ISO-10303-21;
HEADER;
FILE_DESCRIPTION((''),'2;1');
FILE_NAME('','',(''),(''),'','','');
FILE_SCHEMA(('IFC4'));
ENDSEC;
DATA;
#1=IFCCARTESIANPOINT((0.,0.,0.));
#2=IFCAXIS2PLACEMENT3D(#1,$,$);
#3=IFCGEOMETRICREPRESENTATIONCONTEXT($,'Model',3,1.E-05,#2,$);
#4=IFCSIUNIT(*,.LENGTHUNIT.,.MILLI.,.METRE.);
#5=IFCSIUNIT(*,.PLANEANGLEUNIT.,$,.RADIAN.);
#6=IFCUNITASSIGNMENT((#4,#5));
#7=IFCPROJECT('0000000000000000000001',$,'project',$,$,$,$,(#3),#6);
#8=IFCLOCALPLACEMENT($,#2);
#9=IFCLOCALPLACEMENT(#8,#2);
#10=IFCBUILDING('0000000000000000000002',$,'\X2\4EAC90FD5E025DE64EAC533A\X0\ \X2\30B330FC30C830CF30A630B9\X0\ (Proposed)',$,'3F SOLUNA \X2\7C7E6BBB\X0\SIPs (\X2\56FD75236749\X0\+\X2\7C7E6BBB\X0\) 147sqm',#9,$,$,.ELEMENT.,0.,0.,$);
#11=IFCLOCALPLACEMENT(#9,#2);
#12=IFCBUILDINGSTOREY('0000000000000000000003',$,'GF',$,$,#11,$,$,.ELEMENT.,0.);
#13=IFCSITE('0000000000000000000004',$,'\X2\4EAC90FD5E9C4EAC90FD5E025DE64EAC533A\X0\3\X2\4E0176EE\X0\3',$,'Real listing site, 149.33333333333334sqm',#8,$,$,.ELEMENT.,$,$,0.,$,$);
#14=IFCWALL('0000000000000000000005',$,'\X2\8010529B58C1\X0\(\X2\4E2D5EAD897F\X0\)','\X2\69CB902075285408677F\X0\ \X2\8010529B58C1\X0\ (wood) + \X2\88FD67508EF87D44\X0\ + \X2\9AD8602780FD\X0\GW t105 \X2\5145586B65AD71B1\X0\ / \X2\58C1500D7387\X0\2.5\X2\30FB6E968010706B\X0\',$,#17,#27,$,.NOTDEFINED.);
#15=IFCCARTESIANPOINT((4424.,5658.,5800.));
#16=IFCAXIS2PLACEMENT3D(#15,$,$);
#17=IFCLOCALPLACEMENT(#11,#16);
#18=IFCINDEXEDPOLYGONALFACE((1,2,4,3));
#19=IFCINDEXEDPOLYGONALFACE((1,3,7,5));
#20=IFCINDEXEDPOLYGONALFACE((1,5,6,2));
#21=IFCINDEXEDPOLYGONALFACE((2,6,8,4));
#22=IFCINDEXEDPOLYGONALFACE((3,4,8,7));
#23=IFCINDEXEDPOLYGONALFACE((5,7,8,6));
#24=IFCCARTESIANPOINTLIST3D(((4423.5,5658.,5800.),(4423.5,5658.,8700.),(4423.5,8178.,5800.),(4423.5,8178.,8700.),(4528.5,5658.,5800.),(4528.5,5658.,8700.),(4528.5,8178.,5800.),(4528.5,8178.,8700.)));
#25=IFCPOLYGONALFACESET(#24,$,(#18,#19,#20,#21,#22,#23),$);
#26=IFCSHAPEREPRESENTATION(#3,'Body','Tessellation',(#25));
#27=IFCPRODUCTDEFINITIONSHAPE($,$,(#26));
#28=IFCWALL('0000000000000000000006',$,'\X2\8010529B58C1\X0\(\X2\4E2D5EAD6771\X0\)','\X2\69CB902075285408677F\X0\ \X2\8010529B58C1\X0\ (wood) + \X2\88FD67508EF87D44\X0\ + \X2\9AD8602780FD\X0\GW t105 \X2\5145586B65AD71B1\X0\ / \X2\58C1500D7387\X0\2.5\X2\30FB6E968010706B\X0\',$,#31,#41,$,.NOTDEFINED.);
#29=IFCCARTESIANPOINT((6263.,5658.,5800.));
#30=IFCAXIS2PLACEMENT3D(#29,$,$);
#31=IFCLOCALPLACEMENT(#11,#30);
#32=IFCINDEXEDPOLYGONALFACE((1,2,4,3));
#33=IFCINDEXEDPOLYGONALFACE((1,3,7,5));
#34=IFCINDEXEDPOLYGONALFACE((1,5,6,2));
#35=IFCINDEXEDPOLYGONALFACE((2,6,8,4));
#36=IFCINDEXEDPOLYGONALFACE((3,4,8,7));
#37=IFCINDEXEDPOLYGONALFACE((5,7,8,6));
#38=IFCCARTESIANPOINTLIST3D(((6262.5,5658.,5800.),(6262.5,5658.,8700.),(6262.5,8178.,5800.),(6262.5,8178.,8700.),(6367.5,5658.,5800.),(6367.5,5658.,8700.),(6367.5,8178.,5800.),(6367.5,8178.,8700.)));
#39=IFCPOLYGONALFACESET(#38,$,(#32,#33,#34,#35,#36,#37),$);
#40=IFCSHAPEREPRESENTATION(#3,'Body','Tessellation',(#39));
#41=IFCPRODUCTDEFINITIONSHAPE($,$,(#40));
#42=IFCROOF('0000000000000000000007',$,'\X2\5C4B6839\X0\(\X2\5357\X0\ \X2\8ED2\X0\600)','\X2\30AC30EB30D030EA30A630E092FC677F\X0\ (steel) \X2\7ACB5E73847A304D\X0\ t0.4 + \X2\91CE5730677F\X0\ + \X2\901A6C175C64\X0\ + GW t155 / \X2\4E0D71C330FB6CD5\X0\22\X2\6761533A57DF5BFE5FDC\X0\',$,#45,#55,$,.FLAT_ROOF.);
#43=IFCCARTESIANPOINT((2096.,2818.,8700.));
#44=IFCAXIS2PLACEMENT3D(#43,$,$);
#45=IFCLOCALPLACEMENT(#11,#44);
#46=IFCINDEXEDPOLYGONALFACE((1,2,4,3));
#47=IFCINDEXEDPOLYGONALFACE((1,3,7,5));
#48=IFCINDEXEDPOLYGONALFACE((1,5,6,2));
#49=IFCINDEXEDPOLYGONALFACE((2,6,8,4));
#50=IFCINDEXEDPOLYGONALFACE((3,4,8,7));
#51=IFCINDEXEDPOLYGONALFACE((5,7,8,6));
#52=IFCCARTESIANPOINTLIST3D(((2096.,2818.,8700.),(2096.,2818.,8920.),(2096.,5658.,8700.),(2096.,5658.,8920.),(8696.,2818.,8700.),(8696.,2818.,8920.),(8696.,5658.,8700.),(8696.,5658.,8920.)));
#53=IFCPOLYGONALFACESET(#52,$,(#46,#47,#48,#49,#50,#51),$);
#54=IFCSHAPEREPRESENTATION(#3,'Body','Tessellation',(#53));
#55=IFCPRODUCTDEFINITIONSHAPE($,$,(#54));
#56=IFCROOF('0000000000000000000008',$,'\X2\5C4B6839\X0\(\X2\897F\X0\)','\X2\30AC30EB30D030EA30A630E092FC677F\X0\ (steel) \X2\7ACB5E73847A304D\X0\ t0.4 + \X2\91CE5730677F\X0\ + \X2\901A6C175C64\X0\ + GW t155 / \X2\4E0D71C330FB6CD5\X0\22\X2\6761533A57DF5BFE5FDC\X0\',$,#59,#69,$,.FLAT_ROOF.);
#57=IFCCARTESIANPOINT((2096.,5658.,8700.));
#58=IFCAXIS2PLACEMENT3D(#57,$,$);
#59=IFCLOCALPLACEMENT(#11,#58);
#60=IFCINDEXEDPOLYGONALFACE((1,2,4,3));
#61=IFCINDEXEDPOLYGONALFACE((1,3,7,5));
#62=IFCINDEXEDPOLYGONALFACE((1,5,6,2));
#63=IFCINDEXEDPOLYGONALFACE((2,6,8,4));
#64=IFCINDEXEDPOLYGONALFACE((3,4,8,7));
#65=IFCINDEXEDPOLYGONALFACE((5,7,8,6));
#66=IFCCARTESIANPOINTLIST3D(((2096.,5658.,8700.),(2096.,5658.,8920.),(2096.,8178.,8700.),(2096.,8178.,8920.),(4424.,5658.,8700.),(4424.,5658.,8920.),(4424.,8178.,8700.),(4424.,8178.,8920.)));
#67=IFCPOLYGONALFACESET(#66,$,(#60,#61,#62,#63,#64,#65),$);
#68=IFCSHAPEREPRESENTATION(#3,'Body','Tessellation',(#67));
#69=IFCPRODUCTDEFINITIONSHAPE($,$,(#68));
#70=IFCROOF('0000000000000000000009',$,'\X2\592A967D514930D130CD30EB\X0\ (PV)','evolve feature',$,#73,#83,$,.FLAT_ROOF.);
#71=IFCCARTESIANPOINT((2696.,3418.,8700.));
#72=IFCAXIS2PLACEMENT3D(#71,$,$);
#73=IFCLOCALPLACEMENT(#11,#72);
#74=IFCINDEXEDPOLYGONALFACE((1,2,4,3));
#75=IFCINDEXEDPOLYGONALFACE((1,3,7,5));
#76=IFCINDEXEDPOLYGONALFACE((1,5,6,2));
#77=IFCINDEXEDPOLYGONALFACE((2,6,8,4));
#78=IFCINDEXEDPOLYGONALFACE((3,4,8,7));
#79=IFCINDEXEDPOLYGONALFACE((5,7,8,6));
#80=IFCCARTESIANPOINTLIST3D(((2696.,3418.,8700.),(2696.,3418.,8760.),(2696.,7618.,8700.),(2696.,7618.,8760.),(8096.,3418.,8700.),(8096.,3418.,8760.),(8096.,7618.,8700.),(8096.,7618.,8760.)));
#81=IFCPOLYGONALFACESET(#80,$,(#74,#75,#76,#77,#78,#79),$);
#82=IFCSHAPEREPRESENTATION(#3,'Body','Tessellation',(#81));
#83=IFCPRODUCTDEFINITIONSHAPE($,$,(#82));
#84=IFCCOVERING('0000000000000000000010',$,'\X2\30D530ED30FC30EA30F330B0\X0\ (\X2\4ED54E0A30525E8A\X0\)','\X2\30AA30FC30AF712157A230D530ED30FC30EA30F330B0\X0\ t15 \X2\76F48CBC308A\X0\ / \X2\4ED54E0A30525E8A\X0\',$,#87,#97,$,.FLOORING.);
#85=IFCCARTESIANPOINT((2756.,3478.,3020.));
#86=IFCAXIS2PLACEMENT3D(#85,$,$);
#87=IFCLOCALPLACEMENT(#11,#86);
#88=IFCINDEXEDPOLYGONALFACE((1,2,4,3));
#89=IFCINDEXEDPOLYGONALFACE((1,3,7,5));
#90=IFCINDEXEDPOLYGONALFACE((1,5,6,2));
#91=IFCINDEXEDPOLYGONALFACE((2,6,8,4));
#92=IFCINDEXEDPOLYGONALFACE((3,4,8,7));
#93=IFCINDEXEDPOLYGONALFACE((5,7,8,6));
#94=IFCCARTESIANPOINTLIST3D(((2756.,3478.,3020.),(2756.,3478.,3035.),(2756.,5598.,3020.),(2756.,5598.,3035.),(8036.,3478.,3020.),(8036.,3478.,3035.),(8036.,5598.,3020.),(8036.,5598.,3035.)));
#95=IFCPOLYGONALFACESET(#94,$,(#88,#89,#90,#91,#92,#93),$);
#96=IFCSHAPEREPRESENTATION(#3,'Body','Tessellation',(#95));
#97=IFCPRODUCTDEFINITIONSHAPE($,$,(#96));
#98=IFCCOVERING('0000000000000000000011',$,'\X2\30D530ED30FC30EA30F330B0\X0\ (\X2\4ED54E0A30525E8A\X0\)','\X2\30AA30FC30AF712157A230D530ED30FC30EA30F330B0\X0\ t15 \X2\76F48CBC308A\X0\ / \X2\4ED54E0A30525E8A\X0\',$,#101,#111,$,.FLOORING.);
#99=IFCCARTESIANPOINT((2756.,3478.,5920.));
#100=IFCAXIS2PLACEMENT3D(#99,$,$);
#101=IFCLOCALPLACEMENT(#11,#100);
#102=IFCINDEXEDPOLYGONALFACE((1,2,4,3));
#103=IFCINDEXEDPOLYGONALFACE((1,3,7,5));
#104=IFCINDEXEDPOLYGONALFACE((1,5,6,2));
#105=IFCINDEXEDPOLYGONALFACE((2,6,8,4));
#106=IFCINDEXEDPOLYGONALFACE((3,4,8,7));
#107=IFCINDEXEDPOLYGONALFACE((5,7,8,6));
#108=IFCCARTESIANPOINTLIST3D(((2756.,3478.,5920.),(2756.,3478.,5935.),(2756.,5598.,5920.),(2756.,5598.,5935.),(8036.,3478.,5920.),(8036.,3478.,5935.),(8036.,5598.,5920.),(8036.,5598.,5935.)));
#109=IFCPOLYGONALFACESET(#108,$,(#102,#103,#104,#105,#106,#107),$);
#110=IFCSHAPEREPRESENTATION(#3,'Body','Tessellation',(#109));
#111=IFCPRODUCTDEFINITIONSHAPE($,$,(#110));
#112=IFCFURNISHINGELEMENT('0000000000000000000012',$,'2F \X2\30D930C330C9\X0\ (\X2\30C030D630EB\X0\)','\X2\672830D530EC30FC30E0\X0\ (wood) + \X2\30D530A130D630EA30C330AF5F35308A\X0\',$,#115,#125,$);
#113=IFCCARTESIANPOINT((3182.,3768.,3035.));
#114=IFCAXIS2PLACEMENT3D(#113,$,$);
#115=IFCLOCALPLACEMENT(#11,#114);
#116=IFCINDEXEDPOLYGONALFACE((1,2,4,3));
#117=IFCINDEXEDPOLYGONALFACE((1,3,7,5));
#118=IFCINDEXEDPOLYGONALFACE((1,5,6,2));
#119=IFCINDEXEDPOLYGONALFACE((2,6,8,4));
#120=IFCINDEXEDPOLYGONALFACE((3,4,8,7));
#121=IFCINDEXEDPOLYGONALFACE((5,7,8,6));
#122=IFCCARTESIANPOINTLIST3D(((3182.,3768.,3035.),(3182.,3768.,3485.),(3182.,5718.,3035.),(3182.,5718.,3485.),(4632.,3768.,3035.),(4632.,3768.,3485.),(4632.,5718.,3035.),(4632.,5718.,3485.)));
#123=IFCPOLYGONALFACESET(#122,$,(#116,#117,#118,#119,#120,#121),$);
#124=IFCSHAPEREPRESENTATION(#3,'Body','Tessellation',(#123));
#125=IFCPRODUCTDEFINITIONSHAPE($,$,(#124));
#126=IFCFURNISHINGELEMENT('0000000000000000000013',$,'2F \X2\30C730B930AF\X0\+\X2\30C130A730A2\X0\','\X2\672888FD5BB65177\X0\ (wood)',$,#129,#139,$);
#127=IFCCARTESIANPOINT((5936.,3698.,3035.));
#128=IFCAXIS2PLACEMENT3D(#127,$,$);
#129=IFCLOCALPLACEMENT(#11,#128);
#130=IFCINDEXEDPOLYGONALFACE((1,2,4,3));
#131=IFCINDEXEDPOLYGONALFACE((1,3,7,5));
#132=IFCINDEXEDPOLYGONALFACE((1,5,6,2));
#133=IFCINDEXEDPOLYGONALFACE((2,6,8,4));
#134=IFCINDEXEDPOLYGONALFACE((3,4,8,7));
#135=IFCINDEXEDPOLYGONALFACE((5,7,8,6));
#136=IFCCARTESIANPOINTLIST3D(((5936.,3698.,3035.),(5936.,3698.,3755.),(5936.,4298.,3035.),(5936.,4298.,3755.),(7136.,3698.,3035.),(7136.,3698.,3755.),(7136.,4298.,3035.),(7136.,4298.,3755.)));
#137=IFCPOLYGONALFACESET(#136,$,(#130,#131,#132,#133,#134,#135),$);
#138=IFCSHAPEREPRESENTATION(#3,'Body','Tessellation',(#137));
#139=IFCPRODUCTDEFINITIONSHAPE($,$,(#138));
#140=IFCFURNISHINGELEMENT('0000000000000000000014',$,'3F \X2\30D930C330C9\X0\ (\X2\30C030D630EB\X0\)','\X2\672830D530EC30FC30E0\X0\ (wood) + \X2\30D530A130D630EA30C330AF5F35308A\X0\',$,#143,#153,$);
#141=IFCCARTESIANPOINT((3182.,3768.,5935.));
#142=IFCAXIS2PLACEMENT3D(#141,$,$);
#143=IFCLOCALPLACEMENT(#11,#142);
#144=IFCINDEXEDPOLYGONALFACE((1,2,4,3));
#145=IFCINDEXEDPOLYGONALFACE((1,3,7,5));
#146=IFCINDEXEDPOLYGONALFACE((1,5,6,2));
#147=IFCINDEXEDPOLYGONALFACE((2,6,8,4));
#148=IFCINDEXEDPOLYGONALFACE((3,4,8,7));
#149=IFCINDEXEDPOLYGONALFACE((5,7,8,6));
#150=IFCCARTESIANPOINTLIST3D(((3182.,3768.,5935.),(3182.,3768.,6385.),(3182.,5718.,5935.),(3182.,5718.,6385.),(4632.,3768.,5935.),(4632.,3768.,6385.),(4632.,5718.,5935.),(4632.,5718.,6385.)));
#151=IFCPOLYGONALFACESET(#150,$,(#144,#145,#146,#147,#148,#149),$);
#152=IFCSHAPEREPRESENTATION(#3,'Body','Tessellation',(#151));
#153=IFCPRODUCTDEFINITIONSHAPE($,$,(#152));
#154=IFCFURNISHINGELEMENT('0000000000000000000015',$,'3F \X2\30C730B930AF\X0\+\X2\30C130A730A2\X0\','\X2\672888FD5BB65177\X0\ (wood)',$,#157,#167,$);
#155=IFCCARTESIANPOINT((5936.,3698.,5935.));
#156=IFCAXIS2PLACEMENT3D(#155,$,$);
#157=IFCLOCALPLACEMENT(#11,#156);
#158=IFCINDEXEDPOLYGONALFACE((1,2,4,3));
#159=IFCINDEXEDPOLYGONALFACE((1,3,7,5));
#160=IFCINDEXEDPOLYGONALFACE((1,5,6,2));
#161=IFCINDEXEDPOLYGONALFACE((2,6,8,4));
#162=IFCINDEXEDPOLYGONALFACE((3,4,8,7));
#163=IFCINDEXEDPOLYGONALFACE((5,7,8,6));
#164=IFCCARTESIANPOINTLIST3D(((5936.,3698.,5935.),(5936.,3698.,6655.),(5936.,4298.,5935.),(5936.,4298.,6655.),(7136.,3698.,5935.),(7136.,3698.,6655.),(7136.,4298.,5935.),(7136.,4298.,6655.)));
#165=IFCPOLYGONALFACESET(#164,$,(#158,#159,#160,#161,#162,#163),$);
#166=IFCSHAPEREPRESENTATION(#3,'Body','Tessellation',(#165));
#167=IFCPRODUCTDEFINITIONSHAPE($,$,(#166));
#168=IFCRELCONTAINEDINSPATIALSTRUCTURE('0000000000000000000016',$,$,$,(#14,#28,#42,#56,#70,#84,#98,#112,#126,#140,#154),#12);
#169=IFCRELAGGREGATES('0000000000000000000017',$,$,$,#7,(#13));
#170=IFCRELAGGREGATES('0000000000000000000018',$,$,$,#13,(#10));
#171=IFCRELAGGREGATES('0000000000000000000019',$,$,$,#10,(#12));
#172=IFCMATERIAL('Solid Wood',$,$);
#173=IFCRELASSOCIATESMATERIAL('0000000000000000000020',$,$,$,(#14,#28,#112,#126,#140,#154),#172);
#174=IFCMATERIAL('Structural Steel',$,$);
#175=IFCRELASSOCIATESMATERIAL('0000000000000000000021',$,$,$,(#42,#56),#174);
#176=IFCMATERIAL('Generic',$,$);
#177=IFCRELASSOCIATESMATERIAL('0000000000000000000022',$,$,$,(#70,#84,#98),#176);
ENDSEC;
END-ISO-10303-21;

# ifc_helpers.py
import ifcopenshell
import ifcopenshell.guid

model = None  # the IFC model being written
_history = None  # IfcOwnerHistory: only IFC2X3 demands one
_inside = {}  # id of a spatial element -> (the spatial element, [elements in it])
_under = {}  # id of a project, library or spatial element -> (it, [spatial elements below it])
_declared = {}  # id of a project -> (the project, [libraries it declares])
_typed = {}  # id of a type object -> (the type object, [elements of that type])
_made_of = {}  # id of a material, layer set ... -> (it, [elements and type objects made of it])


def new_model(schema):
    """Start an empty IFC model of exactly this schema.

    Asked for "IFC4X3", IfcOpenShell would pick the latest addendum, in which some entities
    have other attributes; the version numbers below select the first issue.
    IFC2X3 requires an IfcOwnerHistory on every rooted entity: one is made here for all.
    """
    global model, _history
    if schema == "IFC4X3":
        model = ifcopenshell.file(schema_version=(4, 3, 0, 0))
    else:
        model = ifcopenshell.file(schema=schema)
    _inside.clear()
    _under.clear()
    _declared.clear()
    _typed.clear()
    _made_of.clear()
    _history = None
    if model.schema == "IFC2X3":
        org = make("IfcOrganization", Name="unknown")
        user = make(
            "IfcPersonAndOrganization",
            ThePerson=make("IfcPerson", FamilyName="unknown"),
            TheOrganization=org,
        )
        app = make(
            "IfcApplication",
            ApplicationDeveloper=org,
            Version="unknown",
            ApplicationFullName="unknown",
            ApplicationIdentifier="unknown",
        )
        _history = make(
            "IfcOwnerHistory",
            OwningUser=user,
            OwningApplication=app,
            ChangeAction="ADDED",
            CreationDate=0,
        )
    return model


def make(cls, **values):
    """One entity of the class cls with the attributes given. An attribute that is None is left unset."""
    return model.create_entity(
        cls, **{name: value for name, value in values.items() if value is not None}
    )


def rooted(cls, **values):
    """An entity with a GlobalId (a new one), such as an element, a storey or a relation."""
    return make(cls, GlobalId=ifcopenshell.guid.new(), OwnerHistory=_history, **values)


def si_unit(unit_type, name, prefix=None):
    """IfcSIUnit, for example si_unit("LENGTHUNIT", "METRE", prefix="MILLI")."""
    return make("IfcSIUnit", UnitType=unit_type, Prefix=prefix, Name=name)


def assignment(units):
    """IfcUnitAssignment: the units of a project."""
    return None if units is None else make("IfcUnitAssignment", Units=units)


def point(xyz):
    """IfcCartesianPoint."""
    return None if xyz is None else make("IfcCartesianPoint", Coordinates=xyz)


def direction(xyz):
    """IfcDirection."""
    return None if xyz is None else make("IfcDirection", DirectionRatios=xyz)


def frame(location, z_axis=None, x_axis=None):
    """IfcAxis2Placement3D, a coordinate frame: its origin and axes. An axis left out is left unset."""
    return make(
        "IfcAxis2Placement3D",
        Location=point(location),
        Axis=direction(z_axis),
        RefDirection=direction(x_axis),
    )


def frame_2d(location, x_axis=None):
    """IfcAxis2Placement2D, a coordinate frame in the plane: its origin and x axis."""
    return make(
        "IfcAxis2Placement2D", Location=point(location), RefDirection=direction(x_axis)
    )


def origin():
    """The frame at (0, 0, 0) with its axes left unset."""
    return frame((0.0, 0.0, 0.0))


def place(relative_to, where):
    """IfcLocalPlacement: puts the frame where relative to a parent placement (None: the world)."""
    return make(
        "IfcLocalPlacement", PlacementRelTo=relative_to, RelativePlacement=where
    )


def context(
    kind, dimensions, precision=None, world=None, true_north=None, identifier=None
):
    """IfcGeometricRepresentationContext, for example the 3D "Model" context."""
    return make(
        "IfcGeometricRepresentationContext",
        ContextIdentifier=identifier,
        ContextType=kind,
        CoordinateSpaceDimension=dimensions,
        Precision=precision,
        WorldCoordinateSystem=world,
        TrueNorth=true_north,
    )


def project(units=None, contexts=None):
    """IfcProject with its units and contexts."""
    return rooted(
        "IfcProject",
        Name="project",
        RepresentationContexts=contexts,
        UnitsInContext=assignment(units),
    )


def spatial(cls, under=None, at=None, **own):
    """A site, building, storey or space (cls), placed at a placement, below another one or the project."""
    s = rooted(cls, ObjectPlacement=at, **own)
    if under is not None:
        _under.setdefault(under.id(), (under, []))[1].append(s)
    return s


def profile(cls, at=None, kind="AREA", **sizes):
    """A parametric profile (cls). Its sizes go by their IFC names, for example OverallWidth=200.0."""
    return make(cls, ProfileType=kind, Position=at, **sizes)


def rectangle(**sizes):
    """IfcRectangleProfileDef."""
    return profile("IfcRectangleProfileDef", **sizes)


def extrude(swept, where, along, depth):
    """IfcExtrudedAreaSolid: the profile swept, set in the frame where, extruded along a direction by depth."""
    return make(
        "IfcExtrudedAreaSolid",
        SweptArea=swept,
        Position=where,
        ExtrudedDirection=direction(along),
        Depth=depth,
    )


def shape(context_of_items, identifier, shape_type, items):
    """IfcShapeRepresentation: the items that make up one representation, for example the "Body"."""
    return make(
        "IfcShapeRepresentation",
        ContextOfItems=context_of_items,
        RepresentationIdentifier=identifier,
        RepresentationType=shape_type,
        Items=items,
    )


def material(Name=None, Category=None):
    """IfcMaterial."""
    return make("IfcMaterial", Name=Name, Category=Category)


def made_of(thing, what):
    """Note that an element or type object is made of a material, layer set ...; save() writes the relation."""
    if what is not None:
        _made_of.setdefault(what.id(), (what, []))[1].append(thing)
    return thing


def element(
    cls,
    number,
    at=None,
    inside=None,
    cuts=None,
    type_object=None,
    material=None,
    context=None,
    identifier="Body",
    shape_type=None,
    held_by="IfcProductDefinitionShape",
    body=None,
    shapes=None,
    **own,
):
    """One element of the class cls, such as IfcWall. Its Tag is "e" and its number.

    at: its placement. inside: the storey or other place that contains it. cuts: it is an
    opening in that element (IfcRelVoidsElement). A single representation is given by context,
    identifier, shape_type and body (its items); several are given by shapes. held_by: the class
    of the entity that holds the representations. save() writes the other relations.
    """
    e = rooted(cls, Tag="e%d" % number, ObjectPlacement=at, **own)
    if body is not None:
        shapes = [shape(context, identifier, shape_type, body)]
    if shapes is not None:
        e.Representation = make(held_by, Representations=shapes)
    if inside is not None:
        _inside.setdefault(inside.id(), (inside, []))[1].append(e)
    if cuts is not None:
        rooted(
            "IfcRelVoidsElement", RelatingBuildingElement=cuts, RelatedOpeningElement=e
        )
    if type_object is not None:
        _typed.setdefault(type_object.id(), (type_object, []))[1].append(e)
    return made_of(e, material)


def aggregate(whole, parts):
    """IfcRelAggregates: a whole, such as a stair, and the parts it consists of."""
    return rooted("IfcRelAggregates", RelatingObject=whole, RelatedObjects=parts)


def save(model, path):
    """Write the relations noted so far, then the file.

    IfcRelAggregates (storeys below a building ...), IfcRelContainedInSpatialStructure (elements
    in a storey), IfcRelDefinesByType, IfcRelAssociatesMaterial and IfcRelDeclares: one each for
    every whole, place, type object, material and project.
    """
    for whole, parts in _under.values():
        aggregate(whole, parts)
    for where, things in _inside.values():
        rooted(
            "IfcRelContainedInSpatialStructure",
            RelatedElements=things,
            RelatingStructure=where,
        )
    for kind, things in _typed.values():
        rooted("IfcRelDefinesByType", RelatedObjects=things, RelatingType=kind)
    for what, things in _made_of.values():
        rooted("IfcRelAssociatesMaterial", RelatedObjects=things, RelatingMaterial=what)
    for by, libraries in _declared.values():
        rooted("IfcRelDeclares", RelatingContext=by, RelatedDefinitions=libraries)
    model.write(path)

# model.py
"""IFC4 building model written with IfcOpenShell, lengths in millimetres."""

from ifc_helpers import new_model, si_unit, frame, frame_2d, origin, place, context, project, spatial, rectangle, extrude, material, element, save


model = new_model("IFC4")

# Units and contexts
model_context = context("Model", 3, precision=1e-05, world=origin())
ifc_project = project(units=[si_unit("LENGTHUNIT", "METRE", prefix="MILLI"), si_unit("PLANEANGLEUNIT", "RADIAN")], contexts=[model_context])

# Site, building, storey
site_placement = place(None, origin())
site = spatial("IfcSite", under=ifc_project, at=site_placement, Name="京都府京都市左京区3丁目3", ObjectType="Real listing site, 149.33333333333334sqm", CompositionType="ELEMENT", RefElevation=0.0)
building_placement = place(site_placement, origin())
building = spatial("IfcBuilding", under=site, at=building_placement, Name="京都市左京区 コートハウス (Proposed)", ObjectType="3F SOLUNA 籾殻SIPs (国産杉+籾殻) 147sqm", CompositionType="ELEMENT", ElevationOfRefHeight=0.0, ElevationOfTerrain=0.0)
storey_placement = place(building_placement, origin())
storey = spatial("IfcBuildingStorey", under=building, at=storey_placement, Name="GF", CompositionType="ELEMENT", Elevation=0.0)

# Shared definitions
ifc_material_1 = material(Name="Solid Wood")

# Walls
wall_1_placement = place(storey_placement, frame((4424.0, 5658.0, 5800.0)))
element("IfcWall", 1, at=wall_1_placement, inside=storey, material=ifc_material_1, Name="耐力壁(中庭西)", Description="構造用合板 耐力壁 (wood) + 製材軸組 + 高性能GW t105 充填断熱 / 壁倍率2.5・準耐火", PredefinedType="NOTDEFINED", context=model_context, shape_type="SweptSolid", body=[
    extrude(rectangle(XDim=105.0, YDim=2520.0, at=frame_2d((52.0, 1260.0))), frame((4424.0, 5658.0, 5800.0)), (0.0, 0.0, 1.0), 2900.0),
])
wall_2_placement = place(storey_placement, frame((6263.0, 5658.0, 5800.0)))
element("IfcWall", 2, at=wall_2_placement, inside=storey, material=ifc_material_1, Name="耐力壁(中庭東)", Description="構造用合板 耐力壁 (wood) + 製材軸組 + 高性能GW t105 充填断熱 / 壁倍率2.5・準耐火", PredefinedType="NOTDEFINED", context=model_context, shape_type="SweptSolid", body=[
    extrude(rectangle(XDim=105.0, YDim=2520.0, at=frame_2d((52.0, 1260.0))), frame((6263.0, 5658.0, 5800.0)), (0.0, 0.0, 1.0), 2900.0),
])

# Roofs
ifc_material_2 = material(Name="Structural Steel")
roof_1_placement = place(storey_placement, frame((2096.0, 2818.0, 8700.0)))
element("IfcRoof", 3, at=roof_1_placement, inside=storey, material=ifc_material_2, Name="屋根(南 軒600)", Description="ガルバリウム鋼板 (steel) 立平葺き t0.4 + 野地板 + 通気層 + GW t155 / 不燃・法22条区域対応", PredefinedType="FLAT_ROOF", context=model_context, shape_type="SweptSolid", body=[
    extrude(rectangle(XDim=6600.0, YDim=2840.0, at=frame_2d((3300.0, 1420.0))), frame((2096.0, 2818.0, 8700.0)), (0.0, 0.0, 1.0), 220.0),
])
roof_2_placement = place(storey_placement, frame((2096.0, 5658.0, 8700.0)))
element("IfcRoof", 4, at=roof_2_placement, inside=storey, material=ifc_material_2, Name="屋根(西)", Description="ガルバリウム鋼板 (steel) 立平葺き t0.4 + 野地板 + 通気層 + GW t155 / 不燃・法22条区域対応", PredefinedType="FLAT_ROOF", context=model_context, shape_type="SweptSolid", body=[
    extrude(rectangle(XDim=2328.0, YDim=2520.0, at=frame_2d((1164.0, 1260.0))), frame((2096.0, 5658.0, 8700.0)), (0.0, 0.0, 1.0), 220.0),
])
ifc_material_3 = material(Name="Generic")
roof_3_placement = place(storey_placement, frame((2696.0, 3418.0, 8700.0)))
element("IfcRoof", 5, at=roof_3_placement, inside=storey, material=ifc_material_3, Name="太陽光パネル (PV)", Description="evolve feature", PredefinedType="FLAT_ROOF", context=model_context, shape_type="SweptSolid", body=[
    extrude(rectangle(XDim=5400.0, YDim=4200.0, at=frame_2d((2700.0, 2100.0))), frame((2696.0, 3418.0, 8700.0)), (0.0, 0.0, 1.0), 60.0),
])

# Coverings
covering_1_placement = place(storey_placement, frame((2756.0, 3478.0, 3020.0)))
element("IfcCovering", 6, at=covering_1_placement, inside=storey, material=ifc_material_3, Name="フローリング (仕上げ床)", Description="オーク無垢フローリング t15 直貼り / 仕上げ床", PredefinedType="FLOORING", context=model_context, shape_type="SweptSolid", body=[
    extrude(rectangle(XDim=5280.0, YDim=2120.0, at=frame_2d((2640.0, 1060.0))), frame((2756.0, 3478.0, 3020.0)), (0.0, 0.0, 1.0), 15.0),
])
covering_2_placement = place(storey_placement, frame((2756.0, 3478.0, 5920.0)))
element("IfcCovering", 7, at=covering_2_placement, inside=storey, material=ifc_material_3, Name="フローリング (仕上げ床)", Description="オーク無垢フローリング t15 直貼り / 仕上げ床", PredefinedType="FLOORING", context=model_context, shape_type="SweptSolid", body=[
    extrude(rectangle(XDim=5280.0, YDim=2120.0, at=frame_2d((2640.0, 1060.0))), frame((2756.0, 3478.0, 5920.0)), (0.0, 0.0, 1.0), 15.0),
])

# Furnishing elements
furnishing_1_placement = place(storey_placement, frame((3182.0, 3768.0, 3035.0)))
element("IfcFurnishingElement", 8, at=furnishing_1_placement, inside=storey, material=ifc_material_1, Name="2F ベッド (ダブル)", Description="木フレーム (wood) + ファブリック張り", context=model_context, shape_type="SweptSolid", body=[
    extrude(rectangle(XDim=1450.0, YDim=1950.0, at=frame_2d((725.0, 975.0))), frame((3182.0, 3768.0, 3035.0)), (0.0, 0.0, 1.0), 450.0),
])
furnishing_2_placement = place(storey_placement, frame((5936.0, 3698.0, 3035.0)))
element("IfcFurnishingElement", 9, at=furnishing_2_placement, inside=storey, material=ifc_material_1, Name="2F デスク+チェア", Description="木製家具 (wood)", context=model_context, shape_type="SweptSolid", body=[
    extrude(rectangle(XDim=1200.0, YDim=600.0, at=frame_2d((600.0, 300.0))), frame((5936.0, 3698.0, 3035.0)), (0.0, 0.0, 1.0), 720.0),
])
furnishing_3_placement = place(storey_placement, frame((3182.0, 3768.0, 5935.0)))
element("IfcFurnishingElement", 10, at=furnishing_3_placement, inside=storey, material=ifc_material_1, Name="3F ベッド (ダブル)", Description="木フレーム (wood) + ファブリック張り", context=model_context, shape_type="SweptSolid", body=[
    extrude(rectangle(XDim=1450.0, YDim=1950.0, at=frame_2d((725.0, 975.0))), frame((3182.0, 3768.0, 5935.0)), (0.0, 0.0, 1.0), 450.0),
])
furnishing_4_placement = place(storey_placement, frame((5936.0, 3698.0, 5935.0)))
element("IfcFurnishingElement", 11, at=furnishing_4_placement, inside=storey, material=ifc_material_1, Name="3F デスク+チェア", Description="木製家具 (wood)", context=model_context, shape_type="SweptSolid", body=[
    extrude(rectangle(XDim=1200.0, YDim=600.0, at=frame_2d((600.0, 300.0))), frame((5936.0, 3698.0, 5935.0)), (0.0, 0.0, 1.0), 720.0),
])

save(model, "model.ifc")
